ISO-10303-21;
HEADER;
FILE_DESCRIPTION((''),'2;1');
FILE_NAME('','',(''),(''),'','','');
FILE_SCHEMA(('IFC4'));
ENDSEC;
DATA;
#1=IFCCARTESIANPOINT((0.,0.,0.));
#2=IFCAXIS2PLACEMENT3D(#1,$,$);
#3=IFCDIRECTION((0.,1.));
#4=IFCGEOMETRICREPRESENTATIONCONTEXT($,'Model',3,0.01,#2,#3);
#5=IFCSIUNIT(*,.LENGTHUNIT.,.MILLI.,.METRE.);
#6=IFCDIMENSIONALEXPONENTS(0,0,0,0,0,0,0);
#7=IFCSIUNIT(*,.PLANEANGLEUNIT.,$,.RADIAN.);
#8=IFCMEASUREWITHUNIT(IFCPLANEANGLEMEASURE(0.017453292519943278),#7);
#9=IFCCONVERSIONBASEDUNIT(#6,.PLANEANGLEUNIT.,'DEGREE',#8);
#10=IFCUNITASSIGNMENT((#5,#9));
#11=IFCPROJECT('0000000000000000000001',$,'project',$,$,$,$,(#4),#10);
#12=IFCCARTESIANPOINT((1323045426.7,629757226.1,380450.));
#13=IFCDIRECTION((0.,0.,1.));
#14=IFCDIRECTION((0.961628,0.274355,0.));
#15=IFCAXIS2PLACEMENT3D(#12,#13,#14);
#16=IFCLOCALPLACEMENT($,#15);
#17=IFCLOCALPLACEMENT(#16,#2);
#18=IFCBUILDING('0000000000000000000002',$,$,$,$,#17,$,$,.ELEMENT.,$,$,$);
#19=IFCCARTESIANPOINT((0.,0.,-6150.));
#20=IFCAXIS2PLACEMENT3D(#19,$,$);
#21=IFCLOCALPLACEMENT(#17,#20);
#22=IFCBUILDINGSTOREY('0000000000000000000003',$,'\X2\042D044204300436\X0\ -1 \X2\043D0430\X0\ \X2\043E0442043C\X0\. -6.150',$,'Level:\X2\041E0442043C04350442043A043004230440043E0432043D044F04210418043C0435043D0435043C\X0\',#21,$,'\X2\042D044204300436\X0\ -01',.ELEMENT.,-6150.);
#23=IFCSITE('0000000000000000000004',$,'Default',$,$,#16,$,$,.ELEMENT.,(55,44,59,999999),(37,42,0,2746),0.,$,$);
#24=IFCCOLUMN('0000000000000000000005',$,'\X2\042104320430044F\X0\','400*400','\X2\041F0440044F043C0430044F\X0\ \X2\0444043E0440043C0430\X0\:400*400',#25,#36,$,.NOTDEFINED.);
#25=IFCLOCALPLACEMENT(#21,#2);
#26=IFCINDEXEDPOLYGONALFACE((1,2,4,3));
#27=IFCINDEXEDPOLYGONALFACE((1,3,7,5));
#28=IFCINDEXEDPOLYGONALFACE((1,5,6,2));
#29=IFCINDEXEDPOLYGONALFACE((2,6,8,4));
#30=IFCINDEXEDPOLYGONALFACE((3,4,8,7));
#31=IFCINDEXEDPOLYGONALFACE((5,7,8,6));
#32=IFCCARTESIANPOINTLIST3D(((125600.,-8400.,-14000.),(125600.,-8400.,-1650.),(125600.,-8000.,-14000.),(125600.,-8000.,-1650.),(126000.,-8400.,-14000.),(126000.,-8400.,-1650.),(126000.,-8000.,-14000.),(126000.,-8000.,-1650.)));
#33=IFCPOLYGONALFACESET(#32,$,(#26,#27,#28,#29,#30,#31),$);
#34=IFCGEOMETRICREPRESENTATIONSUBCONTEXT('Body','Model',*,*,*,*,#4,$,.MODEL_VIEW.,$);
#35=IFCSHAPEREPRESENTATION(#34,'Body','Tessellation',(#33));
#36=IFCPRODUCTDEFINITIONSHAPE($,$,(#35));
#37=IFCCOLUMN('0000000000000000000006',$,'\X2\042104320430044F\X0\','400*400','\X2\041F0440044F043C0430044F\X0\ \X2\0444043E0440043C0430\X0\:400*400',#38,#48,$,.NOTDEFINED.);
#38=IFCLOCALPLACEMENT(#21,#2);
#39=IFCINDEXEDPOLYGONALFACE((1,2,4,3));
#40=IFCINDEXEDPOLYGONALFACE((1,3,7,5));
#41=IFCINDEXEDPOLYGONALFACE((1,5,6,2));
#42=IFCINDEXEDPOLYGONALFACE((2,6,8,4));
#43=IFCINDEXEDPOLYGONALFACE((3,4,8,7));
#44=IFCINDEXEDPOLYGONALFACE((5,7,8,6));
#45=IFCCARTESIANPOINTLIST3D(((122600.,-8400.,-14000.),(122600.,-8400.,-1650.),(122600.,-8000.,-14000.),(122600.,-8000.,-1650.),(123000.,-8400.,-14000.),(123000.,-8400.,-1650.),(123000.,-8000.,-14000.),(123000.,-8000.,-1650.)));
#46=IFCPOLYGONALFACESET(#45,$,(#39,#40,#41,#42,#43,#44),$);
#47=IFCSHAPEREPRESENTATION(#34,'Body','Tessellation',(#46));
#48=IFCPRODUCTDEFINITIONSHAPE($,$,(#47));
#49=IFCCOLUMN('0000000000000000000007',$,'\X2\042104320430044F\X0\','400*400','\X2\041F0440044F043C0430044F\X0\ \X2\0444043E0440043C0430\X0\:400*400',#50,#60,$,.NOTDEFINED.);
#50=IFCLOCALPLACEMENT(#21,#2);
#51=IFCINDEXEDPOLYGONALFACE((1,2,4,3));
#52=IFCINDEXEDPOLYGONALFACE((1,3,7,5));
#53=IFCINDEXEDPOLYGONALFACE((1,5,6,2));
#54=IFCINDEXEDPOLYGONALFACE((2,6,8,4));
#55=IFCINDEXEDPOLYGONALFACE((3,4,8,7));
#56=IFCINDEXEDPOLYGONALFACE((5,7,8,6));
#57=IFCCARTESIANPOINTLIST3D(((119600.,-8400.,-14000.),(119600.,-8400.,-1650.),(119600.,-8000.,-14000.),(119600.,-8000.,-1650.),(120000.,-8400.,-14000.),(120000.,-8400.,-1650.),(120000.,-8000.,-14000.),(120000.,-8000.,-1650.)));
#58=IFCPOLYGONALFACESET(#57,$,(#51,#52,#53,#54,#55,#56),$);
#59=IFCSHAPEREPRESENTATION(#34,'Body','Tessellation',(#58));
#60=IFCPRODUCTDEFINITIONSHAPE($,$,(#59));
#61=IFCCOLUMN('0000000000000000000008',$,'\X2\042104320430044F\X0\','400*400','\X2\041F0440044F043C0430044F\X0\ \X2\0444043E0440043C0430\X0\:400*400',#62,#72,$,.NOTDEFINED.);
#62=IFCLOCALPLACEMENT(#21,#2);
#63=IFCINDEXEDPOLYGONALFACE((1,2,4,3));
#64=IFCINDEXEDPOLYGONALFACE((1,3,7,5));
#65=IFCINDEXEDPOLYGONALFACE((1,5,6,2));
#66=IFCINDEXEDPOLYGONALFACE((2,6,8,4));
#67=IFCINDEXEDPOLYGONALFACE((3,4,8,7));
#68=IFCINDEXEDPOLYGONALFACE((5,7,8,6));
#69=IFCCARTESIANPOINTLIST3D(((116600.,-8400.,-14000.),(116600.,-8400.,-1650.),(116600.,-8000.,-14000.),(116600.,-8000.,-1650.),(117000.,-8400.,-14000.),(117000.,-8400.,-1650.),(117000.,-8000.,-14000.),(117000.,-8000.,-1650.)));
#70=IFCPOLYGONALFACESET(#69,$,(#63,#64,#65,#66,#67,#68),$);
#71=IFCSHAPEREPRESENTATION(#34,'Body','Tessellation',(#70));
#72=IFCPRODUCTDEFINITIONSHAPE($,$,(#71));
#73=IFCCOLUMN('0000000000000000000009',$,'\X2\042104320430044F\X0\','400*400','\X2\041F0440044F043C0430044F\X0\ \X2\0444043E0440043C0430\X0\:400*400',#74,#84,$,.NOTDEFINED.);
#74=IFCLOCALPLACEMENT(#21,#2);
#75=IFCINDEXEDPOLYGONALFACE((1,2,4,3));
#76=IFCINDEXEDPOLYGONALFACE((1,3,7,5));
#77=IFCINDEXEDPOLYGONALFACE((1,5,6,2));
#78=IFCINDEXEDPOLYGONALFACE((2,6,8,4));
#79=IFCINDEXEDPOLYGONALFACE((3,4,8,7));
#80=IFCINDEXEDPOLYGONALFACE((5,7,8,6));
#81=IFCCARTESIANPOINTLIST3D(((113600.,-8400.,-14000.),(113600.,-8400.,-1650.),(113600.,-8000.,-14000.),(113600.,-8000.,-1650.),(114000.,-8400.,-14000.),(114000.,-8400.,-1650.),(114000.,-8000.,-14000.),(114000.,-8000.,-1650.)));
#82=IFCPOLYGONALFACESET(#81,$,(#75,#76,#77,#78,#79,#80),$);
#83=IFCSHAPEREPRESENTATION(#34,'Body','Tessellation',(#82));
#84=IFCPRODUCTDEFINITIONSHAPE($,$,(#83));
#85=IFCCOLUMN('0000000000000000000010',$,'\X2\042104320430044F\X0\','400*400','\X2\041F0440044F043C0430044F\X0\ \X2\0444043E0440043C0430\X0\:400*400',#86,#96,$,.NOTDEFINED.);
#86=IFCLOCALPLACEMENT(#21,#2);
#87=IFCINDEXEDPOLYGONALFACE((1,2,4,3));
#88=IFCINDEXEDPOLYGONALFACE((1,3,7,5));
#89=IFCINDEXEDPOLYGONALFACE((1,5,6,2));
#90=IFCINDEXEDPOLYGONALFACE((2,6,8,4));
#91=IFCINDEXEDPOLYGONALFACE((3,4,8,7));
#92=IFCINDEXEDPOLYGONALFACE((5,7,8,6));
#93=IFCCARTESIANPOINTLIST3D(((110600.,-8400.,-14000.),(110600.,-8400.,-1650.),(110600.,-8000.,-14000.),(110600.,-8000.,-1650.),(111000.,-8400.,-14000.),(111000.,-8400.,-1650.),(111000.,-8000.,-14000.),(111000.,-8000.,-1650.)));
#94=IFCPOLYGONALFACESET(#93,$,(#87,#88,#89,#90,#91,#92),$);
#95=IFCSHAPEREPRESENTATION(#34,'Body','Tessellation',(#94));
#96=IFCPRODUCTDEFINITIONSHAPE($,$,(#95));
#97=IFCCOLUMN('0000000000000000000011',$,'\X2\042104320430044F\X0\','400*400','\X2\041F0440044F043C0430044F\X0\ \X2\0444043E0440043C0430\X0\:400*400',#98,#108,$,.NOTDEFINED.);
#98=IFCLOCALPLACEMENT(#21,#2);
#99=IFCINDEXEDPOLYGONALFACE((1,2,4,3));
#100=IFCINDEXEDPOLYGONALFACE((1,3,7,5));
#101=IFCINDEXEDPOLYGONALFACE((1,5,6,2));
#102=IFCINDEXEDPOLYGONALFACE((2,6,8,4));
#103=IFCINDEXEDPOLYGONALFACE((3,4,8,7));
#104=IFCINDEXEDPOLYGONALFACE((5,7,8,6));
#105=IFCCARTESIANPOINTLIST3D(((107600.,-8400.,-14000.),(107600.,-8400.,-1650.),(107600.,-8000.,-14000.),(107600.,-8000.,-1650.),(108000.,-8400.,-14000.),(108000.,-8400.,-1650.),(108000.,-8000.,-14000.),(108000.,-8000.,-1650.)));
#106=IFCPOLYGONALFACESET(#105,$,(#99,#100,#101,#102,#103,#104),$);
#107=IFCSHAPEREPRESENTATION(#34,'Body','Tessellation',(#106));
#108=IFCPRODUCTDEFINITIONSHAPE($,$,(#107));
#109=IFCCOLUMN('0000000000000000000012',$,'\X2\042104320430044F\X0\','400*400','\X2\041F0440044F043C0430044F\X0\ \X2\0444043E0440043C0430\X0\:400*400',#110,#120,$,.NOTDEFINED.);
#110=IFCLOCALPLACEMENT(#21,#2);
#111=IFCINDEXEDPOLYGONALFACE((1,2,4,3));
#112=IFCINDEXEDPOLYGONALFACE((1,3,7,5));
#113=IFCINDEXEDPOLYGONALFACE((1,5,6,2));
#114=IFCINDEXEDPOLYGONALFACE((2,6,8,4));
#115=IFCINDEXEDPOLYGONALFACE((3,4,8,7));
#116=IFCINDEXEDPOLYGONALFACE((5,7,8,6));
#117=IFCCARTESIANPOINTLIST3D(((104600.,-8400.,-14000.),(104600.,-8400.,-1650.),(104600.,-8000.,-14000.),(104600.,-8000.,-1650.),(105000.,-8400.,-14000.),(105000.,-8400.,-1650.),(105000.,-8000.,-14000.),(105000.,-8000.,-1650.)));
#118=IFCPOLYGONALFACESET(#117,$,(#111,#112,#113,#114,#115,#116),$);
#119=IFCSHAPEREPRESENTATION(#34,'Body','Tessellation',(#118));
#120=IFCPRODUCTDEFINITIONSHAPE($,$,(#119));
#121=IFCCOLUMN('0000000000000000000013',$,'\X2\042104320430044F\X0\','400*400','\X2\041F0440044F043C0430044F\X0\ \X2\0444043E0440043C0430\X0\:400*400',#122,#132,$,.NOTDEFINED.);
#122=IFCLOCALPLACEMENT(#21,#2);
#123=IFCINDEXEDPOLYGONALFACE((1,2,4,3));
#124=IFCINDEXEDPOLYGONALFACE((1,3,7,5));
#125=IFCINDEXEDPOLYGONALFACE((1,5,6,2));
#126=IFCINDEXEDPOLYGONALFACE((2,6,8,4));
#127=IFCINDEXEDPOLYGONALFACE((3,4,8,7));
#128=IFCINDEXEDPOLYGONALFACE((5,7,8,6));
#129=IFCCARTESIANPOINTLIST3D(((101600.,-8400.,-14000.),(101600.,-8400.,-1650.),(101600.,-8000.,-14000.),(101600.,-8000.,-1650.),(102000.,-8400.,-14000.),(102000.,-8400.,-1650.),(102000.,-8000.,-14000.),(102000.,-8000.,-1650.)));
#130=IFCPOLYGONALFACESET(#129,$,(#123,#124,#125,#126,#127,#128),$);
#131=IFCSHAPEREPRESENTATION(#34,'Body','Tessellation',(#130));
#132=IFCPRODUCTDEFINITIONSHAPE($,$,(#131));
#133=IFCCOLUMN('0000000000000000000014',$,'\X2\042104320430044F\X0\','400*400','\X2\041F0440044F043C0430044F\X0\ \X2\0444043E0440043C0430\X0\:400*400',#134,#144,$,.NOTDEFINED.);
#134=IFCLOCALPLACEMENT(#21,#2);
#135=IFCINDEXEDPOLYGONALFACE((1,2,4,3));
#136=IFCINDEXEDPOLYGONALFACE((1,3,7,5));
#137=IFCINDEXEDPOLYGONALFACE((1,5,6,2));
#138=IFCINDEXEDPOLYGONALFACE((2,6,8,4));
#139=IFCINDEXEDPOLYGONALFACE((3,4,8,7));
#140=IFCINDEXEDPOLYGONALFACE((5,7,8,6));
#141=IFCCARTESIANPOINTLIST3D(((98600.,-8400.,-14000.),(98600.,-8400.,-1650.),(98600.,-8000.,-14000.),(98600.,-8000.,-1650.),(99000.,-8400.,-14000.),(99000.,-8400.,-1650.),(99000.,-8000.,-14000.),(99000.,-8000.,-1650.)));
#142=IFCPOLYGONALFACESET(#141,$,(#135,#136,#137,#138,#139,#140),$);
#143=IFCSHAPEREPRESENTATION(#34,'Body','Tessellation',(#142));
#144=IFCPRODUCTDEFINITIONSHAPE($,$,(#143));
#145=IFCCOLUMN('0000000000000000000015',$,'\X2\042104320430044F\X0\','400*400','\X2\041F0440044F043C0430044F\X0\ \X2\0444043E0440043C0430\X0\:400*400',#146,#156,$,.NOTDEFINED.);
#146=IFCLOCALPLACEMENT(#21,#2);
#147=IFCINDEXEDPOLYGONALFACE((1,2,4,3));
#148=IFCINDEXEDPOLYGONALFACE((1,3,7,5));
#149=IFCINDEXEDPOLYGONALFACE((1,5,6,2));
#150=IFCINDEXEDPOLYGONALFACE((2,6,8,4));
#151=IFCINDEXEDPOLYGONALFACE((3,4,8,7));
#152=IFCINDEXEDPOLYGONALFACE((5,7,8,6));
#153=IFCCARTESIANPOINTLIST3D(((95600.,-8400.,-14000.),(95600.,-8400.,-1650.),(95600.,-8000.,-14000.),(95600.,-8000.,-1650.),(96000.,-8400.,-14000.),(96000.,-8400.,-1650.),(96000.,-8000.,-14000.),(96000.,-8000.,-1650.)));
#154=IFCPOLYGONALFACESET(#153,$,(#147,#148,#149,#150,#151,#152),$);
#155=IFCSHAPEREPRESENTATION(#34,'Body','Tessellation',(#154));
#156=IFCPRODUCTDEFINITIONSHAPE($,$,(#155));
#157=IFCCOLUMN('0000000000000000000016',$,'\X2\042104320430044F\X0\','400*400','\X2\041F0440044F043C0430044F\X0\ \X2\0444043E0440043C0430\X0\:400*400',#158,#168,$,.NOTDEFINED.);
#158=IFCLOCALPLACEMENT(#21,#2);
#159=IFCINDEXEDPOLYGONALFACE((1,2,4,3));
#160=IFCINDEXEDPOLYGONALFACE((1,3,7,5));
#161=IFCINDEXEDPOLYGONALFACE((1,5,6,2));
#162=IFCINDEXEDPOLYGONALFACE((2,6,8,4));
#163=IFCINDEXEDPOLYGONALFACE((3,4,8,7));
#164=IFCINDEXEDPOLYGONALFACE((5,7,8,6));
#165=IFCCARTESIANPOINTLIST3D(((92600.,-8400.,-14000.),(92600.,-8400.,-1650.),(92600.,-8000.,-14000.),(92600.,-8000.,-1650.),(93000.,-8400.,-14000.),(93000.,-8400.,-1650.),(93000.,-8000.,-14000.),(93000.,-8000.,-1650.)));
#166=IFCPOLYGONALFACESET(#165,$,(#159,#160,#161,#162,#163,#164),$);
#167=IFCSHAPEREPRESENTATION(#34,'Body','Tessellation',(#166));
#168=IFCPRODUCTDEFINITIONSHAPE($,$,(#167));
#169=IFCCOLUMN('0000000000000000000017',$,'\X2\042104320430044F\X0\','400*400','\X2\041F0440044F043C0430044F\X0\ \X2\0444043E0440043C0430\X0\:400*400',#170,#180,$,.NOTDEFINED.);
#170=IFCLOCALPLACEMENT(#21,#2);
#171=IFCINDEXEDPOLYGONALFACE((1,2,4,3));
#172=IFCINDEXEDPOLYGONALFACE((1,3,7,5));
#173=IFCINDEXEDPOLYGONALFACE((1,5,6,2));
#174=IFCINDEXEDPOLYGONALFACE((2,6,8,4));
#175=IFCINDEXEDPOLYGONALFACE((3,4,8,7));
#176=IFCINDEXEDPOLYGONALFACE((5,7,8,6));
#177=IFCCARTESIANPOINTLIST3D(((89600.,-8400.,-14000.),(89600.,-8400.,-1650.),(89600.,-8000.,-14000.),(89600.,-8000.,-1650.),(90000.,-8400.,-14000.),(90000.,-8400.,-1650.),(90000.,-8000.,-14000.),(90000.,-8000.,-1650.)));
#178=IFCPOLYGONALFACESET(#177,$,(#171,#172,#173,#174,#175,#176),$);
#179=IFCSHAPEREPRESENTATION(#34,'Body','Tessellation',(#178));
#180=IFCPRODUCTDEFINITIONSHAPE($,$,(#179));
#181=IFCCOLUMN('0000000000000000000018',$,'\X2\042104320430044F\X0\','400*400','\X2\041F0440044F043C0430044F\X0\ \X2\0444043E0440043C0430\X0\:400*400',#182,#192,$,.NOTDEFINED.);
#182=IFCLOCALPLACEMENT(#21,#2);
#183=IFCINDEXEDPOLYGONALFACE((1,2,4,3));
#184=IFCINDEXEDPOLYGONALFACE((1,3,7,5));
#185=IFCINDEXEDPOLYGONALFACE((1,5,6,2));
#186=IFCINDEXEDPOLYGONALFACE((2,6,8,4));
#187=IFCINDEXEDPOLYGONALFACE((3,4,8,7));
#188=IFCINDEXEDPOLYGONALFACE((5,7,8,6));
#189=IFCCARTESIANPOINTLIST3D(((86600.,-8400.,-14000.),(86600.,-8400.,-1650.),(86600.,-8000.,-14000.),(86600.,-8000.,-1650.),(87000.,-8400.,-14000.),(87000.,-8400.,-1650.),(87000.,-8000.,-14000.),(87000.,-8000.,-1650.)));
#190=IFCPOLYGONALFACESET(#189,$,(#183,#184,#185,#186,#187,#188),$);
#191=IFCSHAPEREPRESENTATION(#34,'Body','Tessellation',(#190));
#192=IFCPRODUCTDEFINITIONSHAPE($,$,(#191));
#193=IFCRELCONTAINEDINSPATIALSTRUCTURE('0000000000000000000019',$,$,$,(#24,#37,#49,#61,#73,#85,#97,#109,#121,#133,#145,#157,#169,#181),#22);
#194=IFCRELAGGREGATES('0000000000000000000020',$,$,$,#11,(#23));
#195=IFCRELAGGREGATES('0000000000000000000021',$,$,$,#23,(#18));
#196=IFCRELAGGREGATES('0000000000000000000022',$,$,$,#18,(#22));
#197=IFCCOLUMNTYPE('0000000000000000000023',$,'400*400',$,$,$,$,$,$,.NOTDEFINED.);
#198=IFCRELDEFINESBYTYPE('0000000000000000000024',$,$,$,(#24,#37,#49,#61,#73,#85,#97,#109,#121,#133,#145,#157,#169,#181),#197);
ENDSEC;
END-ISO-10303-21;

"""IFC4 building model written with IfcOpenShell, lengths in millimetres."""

from ifc_helpers import new_model, entity, si_unit, converted_unit, direction, frame, origin, place, context, subcontext, project, spatial, indexed_curve, outline, extrude, type_object, element, save


model = new_model("IFC4")

# Units and contexts
model_context = context("Model", 3, precision=0.01, world=origin(), true_north=direction((0.0, 1.0)))
body_context = subcontext(model_context, "Body", "Model", "MODEL_VIEW")
ifc_project = project(units=[si_unit("LENGTHUNIT", "METRE", prefix="MILLI"), converted_unit("PLANEANGLEUNIT", "DEGREE", entity("IfcPlaneAngleMeasure", 0.017453292519943278), si_unit("PLANEANGLEUNIT", "RADIAN"), dimensions=[0, 0, 0, 0, 0, 0, 0])], contexts=[model_context])

# Site, building, storey
site_placement = place(None, frame((1323045426.7, 629757226.1, 380450.0), z_axis=(0.0, 0.0, 1.0), x_axis=(0.961628, 0.274355, 0.0)))
site = spatial("IfcSite", under=ifc_project, at=site_placement, Name="Default", CompositionType="ELEMENT", RefLatitude=(55, 44, 59, 999999), RefLongitude=(37, 42, 0, 2746), RefElevation=0.0)
building_placement = place(site_placement, origin())
building = spatial("IfcBuilding", under=site, at=building_placement, CompositionType="ELEMENT")
storey_placement = place(building_placement, frame((0.0, 0.0, -6150.0)))
storey = spatial("IfcBuildingStorey", under=building, at=storey_placement, Name="Этаж -1 на отм. -6.150", ObjectType="Level:ОтметкаУровняСИменем", LongName="Этаж -01", CompositionType="ELEMENT", Elevation=-6150.0)

# Columns
column_type = type_object("IfcColumnType", Name="400*400", PredefinedType="NOTDEFINED")
column_1_placement = place(storey_placement, origin())
element("IfcColumn", 1, at=column_1_placement, inside=storey, type_object=column_type, Name="Свая", Description="400*400", ObjectType="Прямая форма:400*400", PredefinedType="NOTDEFINED", context=body_context, shape_type="SweptSolid", body=[
    extrude(outline(indexed_curve([(-200.0, -200.0), (200.0, -200.0), (200.0, 200.0), (-200.0, 200.0), (-200.0, -200.0)], self_intersect=False)), frame((125800.0, -8200.0, -14000.0), z_axis=(0.0, 0.0, 1.0), x_axis=(0.0, 1.0, 0.0)), (0.0, 0.0, 1.0), 12350.0),
])
column_2_placement = place(storey_placement, origin())
element("IfcColumn", 2, at=column_2_placement, inside=storey, type_object=column_type, Name="Свая", Description="400*400", ObjectType="Прямая форма:400*400", PredefinedType="NOTDEFINED", context=body_context, shape_type="SweptSolid", body=[
    extrude(outline(indexed_curve([(-200.0, -200.0), (200.0, -200.0), (200.0, 200.0), (-200.0, 200.0), (-200.0, -200.0)], self_intersect=False)), frame((122800.0, -8200.0, -14000.0), z_axis=(0.0, 0.0, 1.0), x_axis=(0.0, 1.0, 0.0)), (0.0, 0.0, 1.0), 12350.0),
])
column_3_placement = place(storey_placement, origin())
element("IfcColumn", 3, at=column_3_placement, inside=storey, type_object=column_type, Name="Свая", Description="400*400", ObjectType="Прямая форма:400*400", PredefinedType="NOTDEFINED", context=body_context, shape_type="SweptSolid", body=[
    extrude(outline(indexed_curve([(-200.0, -200.0), (200.0, -200.0), (200.0, 200.0), (-200.0, 200.0), (-200.0, -200.0)], self_intersect=False)), frame((119800.0, -8200.0, -14000.0), z_axis=(0.0, 0.0, 1.0), x_axis=(0.0, 1.0, 0.0)), (0.0, 0.0, 1.0), 12350.0),
])
column_4_placement = place(storey_placement, origin())
element("IfcColumn", 4, at=column_4_placement, inside=storey, type_object=column_type, Name="Свая", Description="400*400", ObjectType="Прямая форма:400*400", PredefinedType="NOTDEFINED", context=body_context, shape_type="SweptSolid", body=[
    extrude(outline(indexed_curve([(-200.0, -200.0), (200.0, -200.0), (200.0, 200.0), (-200.0, 200.0), (-200.0, -200.0)], self_intersect=False)), frame((116800.0, -8200.0, -14000.0), z_axis=(0.0, 0.0, 1.0), x_axis=(0.0, 1.0, 0.0)), (0.0, 0.0, 1.0), 12350.0),
])
column_5_placement = place(storey_placement, origin())
element("IfcColumn", 5, at=column_5_placement, inside=storey, type_object=column_type, Name="Свая", Description="400*400", ObjectType="Прямая форма:400*400", PredefinedType="NOTDEFINED", context=body_context, shape_type="SweptSolid", body=[
    extrude(outline(indexed_curve([(-200.0, -200.0), (200.0, -200.0), (200.0, 200.0), (-200.0, 200.0), (-200.0, -200.0)], self_intersect=False)), frame((113800.0, -8200.0, -14000.0), z_axis=(0.0, 0.0, 1.0), x_axis=(0.0, 1.0, 0.0)), (0.0, 0.0, 1.0), 12350.0),
])
column_6_placement = place(storey_placement, origin())
element("IfcColumn", 6, at=column_6_placement, inside=storey, type_object=column_type, Name="Свая", Description="400*400", ObjectType="Прямая форма:400*400", PredefinedType="NOTDEFINED", context=body_context, shape_type="SweptSolid", body=[
    extrude(outline(indexed_curve([(-200.0, -200.0), (200.0, -200.0), (200.0, 200.0), (-200.0, 200.0), (-200.0, -200.0)], self_intersect=False)), frame((110800.0, -8200.0, -14000.0), z_axis=(0.0, 0.0, 1.0), x_axis=(0.0, 1.0, 0.0)), (0.0, 0.0, 1.0), 12350.0),
])
column_7_placement = place(storey_placement, origin())
element("IfcColumn", 7, at=column_7_placement, inside=storey, type_object=column_type, Name="Свая", Description="400*400", ObjectType="Прямая форма:400*400", PredefinedType="NOTDEFINED", context=body_context, shape_type="SweptSolid", body=[
    extrude(outline(indexed_curve([(-200.0, -200.0), (200.0, -200.0), (200.0, 200.0), (-200.0, 200.0), (-200.0, -200.0)], self_intersect=False)), frame((107800.0, -8200.0, -14000.0), z_axis=(0.0, 0.0, 1.0), x_axis=(0.0, 1.0, 0.0)), (0.0, 0.0, 1.0), 12350.0),
])
column_8_placement = place(storey_placement, origin())
element("IfcColumn", 8, at=column_8_placement, inside=storey, type_object=column_type, Name="Свая", Description="400*400", ObjectType="Прямая форма:400*400", PredefinedType="NOTDEFINED", context=body_context, shape_type="SweptSolid", body=[
    extrude(outline(indexed_curve([(-200.0, -200.0), (200.0, -200.0), (200.0, 200.0), (-200.0, 200.0), (-200.0, -200.0)], self_intersect=False)), frame((104800.0, -8200.0, -14000.0), z_axis=(0.0, 0.0, 1.0), x_axis=(0.0, 1.0, 0.0)), (0.0, 0.0, 1.0), 12350.0),
])
column_9_placement = place(storey_placement, origin())
element("IfcColumn", 9, at=column_9_placement, inside=storey, type_object=column_type, Name="Свая", Description="400*400", ObjectType="Прямая форма:400*400", PredefinedType="NOTDEFINED", context=body_context, shape_type="SweptSolid", body=[
    extrude(outline(indexed_curve([(-200.0, -200.0), (200.0, -200.0), (200.0, 200.0), (-200.0, 200.0), (-200.0, -200.0)], self_intersect=False)), frame((101800.0, -8200.0, -14000.0), z_axis=(0.0, 0.0, 1.0), x_axis=(0.0, 1.0, 0.0)), (0.0, 0.0, 1.0), 12350.0),
])
column_10_placement = place(storey_placement, origin())
element("IfcColumn", 10, at=column_10_placement, inside=storey, type_object=column_type, Name="Свая", Description="400*400", ObjectType="Прямая форма:400*400", PredefinedType="NOTDEFINED", context=body_context, shape_type="SweptSolid", body=[
    extrude(outline(indexed_curve([(-200.0, -200.0), (200.0, -200.0), (200.0, 200.0), (-200.0, 200.0), (-200.0, -200.0)], self_intersect=False)), frame((98800.0, -8200.0, -14000.0), z_axis=(0.0, 0.0, 1.0), x_axis=(0.0, 1.0, 0.0)), (0.0, 0.0, 1.0), 12350.0),
])
column_11_placement = place(storey_placement, origin())
element("IfcColumn", 11, at=column_11_placement, inside=storey, type_object=column_type, Name="Свая", Description="400*400", ObjectType="Прямая форма:400*400", PredefinedType="NOTDEFINED", context=body_context, shape_type="SweptSolid", body=[
    extrude(outline(indexed_curve([(-200.0, -200.0), (200.0, -200.0), (200.0, 200.0), (-200.0, 200.0), (-200.0, -200.0)], self_intersect=False)), frame((95800.0, -8200.0, -14000.0), z_axis=(0.0, 0.0, 1.0), x_axis=(0.0, 1.0, 0.0)), (0.0, 0.0, 1.0), 12350.0),
])
column_12_placement = place(storey_placement, origin())
element("IfcColumn", 12, at=column_12_placement, inside=storey, type_object=column_type, Name="Свая", Description="400*400", ObjectType="Прямая форма:400*400", PredefinedType="NOTDEFINED", context=body_context, shape_type="SweptSolid", body=[
    extrude(outline(indexed_curve([(-200.0, -200.0), (200.0, -200.0), (200.0, 200.0), (-200.0, 200.0), (-200.0, -200.0)], self_intersect=False)), frame((92800.0, -8200.0, -14000.0), z_axis=(0.0, 0.0, 1.0), x_axis=(0.0, 1.0, 0.0)), (0.0, 0.0, 1.0), 12350.0),
])
column_13_placement = place(storey_placement, origin())
element("IfcColumn", 13, at=column_13_placement, inside=storey, type_object=column_type, Name="Свая", Description="400*400", ObjectType="Прямая форма:400*400", PredefinedType="NOTDEFINED", context=body_context, shape_type="SweptSolid", body=[
    extrude(outline(indexed_curve([(-200.0, -200.0), (200.0, -200.0), (200.0, 200.0), (-200.0, 200.0), (-200.0, -200.0)], self_intersect=False)), frame((89800.0, -8200.0, -14000.0), z_axis=(0.0, 0.0, 1.0), x_axis=(0.0, 1.0, 0.0)), (0.0, 0.0, 1.0), 12350.0),
])
column_14_placement = place(storey_placement, origin())
element("IfcColumn", 14, at=column_14_placement, inside=storey, type_object=column_type, Name="Свая", Description="400*400", ObjectType="Прямая форма:400*400", PredefinedType="NOTDEFINED", context=body_context, shape_type="SweptSolid", body=[
    extrude(outline(indexed_curve([(-200.0, -200.0), (200.0, -200.0), (200.0, 200.0), (-200.0, 200.0), (-200.0, -200.0)], self_intersect=False)), frame((86800.0, -8200.0, -14000.0), z_axis=(0.0, 0.0, 1.0), x_axis=(0.0, 1.0, 0.0)), (0.0, 0.0, 1.0), 12350.0),
])

save(model, "model.ifc")
